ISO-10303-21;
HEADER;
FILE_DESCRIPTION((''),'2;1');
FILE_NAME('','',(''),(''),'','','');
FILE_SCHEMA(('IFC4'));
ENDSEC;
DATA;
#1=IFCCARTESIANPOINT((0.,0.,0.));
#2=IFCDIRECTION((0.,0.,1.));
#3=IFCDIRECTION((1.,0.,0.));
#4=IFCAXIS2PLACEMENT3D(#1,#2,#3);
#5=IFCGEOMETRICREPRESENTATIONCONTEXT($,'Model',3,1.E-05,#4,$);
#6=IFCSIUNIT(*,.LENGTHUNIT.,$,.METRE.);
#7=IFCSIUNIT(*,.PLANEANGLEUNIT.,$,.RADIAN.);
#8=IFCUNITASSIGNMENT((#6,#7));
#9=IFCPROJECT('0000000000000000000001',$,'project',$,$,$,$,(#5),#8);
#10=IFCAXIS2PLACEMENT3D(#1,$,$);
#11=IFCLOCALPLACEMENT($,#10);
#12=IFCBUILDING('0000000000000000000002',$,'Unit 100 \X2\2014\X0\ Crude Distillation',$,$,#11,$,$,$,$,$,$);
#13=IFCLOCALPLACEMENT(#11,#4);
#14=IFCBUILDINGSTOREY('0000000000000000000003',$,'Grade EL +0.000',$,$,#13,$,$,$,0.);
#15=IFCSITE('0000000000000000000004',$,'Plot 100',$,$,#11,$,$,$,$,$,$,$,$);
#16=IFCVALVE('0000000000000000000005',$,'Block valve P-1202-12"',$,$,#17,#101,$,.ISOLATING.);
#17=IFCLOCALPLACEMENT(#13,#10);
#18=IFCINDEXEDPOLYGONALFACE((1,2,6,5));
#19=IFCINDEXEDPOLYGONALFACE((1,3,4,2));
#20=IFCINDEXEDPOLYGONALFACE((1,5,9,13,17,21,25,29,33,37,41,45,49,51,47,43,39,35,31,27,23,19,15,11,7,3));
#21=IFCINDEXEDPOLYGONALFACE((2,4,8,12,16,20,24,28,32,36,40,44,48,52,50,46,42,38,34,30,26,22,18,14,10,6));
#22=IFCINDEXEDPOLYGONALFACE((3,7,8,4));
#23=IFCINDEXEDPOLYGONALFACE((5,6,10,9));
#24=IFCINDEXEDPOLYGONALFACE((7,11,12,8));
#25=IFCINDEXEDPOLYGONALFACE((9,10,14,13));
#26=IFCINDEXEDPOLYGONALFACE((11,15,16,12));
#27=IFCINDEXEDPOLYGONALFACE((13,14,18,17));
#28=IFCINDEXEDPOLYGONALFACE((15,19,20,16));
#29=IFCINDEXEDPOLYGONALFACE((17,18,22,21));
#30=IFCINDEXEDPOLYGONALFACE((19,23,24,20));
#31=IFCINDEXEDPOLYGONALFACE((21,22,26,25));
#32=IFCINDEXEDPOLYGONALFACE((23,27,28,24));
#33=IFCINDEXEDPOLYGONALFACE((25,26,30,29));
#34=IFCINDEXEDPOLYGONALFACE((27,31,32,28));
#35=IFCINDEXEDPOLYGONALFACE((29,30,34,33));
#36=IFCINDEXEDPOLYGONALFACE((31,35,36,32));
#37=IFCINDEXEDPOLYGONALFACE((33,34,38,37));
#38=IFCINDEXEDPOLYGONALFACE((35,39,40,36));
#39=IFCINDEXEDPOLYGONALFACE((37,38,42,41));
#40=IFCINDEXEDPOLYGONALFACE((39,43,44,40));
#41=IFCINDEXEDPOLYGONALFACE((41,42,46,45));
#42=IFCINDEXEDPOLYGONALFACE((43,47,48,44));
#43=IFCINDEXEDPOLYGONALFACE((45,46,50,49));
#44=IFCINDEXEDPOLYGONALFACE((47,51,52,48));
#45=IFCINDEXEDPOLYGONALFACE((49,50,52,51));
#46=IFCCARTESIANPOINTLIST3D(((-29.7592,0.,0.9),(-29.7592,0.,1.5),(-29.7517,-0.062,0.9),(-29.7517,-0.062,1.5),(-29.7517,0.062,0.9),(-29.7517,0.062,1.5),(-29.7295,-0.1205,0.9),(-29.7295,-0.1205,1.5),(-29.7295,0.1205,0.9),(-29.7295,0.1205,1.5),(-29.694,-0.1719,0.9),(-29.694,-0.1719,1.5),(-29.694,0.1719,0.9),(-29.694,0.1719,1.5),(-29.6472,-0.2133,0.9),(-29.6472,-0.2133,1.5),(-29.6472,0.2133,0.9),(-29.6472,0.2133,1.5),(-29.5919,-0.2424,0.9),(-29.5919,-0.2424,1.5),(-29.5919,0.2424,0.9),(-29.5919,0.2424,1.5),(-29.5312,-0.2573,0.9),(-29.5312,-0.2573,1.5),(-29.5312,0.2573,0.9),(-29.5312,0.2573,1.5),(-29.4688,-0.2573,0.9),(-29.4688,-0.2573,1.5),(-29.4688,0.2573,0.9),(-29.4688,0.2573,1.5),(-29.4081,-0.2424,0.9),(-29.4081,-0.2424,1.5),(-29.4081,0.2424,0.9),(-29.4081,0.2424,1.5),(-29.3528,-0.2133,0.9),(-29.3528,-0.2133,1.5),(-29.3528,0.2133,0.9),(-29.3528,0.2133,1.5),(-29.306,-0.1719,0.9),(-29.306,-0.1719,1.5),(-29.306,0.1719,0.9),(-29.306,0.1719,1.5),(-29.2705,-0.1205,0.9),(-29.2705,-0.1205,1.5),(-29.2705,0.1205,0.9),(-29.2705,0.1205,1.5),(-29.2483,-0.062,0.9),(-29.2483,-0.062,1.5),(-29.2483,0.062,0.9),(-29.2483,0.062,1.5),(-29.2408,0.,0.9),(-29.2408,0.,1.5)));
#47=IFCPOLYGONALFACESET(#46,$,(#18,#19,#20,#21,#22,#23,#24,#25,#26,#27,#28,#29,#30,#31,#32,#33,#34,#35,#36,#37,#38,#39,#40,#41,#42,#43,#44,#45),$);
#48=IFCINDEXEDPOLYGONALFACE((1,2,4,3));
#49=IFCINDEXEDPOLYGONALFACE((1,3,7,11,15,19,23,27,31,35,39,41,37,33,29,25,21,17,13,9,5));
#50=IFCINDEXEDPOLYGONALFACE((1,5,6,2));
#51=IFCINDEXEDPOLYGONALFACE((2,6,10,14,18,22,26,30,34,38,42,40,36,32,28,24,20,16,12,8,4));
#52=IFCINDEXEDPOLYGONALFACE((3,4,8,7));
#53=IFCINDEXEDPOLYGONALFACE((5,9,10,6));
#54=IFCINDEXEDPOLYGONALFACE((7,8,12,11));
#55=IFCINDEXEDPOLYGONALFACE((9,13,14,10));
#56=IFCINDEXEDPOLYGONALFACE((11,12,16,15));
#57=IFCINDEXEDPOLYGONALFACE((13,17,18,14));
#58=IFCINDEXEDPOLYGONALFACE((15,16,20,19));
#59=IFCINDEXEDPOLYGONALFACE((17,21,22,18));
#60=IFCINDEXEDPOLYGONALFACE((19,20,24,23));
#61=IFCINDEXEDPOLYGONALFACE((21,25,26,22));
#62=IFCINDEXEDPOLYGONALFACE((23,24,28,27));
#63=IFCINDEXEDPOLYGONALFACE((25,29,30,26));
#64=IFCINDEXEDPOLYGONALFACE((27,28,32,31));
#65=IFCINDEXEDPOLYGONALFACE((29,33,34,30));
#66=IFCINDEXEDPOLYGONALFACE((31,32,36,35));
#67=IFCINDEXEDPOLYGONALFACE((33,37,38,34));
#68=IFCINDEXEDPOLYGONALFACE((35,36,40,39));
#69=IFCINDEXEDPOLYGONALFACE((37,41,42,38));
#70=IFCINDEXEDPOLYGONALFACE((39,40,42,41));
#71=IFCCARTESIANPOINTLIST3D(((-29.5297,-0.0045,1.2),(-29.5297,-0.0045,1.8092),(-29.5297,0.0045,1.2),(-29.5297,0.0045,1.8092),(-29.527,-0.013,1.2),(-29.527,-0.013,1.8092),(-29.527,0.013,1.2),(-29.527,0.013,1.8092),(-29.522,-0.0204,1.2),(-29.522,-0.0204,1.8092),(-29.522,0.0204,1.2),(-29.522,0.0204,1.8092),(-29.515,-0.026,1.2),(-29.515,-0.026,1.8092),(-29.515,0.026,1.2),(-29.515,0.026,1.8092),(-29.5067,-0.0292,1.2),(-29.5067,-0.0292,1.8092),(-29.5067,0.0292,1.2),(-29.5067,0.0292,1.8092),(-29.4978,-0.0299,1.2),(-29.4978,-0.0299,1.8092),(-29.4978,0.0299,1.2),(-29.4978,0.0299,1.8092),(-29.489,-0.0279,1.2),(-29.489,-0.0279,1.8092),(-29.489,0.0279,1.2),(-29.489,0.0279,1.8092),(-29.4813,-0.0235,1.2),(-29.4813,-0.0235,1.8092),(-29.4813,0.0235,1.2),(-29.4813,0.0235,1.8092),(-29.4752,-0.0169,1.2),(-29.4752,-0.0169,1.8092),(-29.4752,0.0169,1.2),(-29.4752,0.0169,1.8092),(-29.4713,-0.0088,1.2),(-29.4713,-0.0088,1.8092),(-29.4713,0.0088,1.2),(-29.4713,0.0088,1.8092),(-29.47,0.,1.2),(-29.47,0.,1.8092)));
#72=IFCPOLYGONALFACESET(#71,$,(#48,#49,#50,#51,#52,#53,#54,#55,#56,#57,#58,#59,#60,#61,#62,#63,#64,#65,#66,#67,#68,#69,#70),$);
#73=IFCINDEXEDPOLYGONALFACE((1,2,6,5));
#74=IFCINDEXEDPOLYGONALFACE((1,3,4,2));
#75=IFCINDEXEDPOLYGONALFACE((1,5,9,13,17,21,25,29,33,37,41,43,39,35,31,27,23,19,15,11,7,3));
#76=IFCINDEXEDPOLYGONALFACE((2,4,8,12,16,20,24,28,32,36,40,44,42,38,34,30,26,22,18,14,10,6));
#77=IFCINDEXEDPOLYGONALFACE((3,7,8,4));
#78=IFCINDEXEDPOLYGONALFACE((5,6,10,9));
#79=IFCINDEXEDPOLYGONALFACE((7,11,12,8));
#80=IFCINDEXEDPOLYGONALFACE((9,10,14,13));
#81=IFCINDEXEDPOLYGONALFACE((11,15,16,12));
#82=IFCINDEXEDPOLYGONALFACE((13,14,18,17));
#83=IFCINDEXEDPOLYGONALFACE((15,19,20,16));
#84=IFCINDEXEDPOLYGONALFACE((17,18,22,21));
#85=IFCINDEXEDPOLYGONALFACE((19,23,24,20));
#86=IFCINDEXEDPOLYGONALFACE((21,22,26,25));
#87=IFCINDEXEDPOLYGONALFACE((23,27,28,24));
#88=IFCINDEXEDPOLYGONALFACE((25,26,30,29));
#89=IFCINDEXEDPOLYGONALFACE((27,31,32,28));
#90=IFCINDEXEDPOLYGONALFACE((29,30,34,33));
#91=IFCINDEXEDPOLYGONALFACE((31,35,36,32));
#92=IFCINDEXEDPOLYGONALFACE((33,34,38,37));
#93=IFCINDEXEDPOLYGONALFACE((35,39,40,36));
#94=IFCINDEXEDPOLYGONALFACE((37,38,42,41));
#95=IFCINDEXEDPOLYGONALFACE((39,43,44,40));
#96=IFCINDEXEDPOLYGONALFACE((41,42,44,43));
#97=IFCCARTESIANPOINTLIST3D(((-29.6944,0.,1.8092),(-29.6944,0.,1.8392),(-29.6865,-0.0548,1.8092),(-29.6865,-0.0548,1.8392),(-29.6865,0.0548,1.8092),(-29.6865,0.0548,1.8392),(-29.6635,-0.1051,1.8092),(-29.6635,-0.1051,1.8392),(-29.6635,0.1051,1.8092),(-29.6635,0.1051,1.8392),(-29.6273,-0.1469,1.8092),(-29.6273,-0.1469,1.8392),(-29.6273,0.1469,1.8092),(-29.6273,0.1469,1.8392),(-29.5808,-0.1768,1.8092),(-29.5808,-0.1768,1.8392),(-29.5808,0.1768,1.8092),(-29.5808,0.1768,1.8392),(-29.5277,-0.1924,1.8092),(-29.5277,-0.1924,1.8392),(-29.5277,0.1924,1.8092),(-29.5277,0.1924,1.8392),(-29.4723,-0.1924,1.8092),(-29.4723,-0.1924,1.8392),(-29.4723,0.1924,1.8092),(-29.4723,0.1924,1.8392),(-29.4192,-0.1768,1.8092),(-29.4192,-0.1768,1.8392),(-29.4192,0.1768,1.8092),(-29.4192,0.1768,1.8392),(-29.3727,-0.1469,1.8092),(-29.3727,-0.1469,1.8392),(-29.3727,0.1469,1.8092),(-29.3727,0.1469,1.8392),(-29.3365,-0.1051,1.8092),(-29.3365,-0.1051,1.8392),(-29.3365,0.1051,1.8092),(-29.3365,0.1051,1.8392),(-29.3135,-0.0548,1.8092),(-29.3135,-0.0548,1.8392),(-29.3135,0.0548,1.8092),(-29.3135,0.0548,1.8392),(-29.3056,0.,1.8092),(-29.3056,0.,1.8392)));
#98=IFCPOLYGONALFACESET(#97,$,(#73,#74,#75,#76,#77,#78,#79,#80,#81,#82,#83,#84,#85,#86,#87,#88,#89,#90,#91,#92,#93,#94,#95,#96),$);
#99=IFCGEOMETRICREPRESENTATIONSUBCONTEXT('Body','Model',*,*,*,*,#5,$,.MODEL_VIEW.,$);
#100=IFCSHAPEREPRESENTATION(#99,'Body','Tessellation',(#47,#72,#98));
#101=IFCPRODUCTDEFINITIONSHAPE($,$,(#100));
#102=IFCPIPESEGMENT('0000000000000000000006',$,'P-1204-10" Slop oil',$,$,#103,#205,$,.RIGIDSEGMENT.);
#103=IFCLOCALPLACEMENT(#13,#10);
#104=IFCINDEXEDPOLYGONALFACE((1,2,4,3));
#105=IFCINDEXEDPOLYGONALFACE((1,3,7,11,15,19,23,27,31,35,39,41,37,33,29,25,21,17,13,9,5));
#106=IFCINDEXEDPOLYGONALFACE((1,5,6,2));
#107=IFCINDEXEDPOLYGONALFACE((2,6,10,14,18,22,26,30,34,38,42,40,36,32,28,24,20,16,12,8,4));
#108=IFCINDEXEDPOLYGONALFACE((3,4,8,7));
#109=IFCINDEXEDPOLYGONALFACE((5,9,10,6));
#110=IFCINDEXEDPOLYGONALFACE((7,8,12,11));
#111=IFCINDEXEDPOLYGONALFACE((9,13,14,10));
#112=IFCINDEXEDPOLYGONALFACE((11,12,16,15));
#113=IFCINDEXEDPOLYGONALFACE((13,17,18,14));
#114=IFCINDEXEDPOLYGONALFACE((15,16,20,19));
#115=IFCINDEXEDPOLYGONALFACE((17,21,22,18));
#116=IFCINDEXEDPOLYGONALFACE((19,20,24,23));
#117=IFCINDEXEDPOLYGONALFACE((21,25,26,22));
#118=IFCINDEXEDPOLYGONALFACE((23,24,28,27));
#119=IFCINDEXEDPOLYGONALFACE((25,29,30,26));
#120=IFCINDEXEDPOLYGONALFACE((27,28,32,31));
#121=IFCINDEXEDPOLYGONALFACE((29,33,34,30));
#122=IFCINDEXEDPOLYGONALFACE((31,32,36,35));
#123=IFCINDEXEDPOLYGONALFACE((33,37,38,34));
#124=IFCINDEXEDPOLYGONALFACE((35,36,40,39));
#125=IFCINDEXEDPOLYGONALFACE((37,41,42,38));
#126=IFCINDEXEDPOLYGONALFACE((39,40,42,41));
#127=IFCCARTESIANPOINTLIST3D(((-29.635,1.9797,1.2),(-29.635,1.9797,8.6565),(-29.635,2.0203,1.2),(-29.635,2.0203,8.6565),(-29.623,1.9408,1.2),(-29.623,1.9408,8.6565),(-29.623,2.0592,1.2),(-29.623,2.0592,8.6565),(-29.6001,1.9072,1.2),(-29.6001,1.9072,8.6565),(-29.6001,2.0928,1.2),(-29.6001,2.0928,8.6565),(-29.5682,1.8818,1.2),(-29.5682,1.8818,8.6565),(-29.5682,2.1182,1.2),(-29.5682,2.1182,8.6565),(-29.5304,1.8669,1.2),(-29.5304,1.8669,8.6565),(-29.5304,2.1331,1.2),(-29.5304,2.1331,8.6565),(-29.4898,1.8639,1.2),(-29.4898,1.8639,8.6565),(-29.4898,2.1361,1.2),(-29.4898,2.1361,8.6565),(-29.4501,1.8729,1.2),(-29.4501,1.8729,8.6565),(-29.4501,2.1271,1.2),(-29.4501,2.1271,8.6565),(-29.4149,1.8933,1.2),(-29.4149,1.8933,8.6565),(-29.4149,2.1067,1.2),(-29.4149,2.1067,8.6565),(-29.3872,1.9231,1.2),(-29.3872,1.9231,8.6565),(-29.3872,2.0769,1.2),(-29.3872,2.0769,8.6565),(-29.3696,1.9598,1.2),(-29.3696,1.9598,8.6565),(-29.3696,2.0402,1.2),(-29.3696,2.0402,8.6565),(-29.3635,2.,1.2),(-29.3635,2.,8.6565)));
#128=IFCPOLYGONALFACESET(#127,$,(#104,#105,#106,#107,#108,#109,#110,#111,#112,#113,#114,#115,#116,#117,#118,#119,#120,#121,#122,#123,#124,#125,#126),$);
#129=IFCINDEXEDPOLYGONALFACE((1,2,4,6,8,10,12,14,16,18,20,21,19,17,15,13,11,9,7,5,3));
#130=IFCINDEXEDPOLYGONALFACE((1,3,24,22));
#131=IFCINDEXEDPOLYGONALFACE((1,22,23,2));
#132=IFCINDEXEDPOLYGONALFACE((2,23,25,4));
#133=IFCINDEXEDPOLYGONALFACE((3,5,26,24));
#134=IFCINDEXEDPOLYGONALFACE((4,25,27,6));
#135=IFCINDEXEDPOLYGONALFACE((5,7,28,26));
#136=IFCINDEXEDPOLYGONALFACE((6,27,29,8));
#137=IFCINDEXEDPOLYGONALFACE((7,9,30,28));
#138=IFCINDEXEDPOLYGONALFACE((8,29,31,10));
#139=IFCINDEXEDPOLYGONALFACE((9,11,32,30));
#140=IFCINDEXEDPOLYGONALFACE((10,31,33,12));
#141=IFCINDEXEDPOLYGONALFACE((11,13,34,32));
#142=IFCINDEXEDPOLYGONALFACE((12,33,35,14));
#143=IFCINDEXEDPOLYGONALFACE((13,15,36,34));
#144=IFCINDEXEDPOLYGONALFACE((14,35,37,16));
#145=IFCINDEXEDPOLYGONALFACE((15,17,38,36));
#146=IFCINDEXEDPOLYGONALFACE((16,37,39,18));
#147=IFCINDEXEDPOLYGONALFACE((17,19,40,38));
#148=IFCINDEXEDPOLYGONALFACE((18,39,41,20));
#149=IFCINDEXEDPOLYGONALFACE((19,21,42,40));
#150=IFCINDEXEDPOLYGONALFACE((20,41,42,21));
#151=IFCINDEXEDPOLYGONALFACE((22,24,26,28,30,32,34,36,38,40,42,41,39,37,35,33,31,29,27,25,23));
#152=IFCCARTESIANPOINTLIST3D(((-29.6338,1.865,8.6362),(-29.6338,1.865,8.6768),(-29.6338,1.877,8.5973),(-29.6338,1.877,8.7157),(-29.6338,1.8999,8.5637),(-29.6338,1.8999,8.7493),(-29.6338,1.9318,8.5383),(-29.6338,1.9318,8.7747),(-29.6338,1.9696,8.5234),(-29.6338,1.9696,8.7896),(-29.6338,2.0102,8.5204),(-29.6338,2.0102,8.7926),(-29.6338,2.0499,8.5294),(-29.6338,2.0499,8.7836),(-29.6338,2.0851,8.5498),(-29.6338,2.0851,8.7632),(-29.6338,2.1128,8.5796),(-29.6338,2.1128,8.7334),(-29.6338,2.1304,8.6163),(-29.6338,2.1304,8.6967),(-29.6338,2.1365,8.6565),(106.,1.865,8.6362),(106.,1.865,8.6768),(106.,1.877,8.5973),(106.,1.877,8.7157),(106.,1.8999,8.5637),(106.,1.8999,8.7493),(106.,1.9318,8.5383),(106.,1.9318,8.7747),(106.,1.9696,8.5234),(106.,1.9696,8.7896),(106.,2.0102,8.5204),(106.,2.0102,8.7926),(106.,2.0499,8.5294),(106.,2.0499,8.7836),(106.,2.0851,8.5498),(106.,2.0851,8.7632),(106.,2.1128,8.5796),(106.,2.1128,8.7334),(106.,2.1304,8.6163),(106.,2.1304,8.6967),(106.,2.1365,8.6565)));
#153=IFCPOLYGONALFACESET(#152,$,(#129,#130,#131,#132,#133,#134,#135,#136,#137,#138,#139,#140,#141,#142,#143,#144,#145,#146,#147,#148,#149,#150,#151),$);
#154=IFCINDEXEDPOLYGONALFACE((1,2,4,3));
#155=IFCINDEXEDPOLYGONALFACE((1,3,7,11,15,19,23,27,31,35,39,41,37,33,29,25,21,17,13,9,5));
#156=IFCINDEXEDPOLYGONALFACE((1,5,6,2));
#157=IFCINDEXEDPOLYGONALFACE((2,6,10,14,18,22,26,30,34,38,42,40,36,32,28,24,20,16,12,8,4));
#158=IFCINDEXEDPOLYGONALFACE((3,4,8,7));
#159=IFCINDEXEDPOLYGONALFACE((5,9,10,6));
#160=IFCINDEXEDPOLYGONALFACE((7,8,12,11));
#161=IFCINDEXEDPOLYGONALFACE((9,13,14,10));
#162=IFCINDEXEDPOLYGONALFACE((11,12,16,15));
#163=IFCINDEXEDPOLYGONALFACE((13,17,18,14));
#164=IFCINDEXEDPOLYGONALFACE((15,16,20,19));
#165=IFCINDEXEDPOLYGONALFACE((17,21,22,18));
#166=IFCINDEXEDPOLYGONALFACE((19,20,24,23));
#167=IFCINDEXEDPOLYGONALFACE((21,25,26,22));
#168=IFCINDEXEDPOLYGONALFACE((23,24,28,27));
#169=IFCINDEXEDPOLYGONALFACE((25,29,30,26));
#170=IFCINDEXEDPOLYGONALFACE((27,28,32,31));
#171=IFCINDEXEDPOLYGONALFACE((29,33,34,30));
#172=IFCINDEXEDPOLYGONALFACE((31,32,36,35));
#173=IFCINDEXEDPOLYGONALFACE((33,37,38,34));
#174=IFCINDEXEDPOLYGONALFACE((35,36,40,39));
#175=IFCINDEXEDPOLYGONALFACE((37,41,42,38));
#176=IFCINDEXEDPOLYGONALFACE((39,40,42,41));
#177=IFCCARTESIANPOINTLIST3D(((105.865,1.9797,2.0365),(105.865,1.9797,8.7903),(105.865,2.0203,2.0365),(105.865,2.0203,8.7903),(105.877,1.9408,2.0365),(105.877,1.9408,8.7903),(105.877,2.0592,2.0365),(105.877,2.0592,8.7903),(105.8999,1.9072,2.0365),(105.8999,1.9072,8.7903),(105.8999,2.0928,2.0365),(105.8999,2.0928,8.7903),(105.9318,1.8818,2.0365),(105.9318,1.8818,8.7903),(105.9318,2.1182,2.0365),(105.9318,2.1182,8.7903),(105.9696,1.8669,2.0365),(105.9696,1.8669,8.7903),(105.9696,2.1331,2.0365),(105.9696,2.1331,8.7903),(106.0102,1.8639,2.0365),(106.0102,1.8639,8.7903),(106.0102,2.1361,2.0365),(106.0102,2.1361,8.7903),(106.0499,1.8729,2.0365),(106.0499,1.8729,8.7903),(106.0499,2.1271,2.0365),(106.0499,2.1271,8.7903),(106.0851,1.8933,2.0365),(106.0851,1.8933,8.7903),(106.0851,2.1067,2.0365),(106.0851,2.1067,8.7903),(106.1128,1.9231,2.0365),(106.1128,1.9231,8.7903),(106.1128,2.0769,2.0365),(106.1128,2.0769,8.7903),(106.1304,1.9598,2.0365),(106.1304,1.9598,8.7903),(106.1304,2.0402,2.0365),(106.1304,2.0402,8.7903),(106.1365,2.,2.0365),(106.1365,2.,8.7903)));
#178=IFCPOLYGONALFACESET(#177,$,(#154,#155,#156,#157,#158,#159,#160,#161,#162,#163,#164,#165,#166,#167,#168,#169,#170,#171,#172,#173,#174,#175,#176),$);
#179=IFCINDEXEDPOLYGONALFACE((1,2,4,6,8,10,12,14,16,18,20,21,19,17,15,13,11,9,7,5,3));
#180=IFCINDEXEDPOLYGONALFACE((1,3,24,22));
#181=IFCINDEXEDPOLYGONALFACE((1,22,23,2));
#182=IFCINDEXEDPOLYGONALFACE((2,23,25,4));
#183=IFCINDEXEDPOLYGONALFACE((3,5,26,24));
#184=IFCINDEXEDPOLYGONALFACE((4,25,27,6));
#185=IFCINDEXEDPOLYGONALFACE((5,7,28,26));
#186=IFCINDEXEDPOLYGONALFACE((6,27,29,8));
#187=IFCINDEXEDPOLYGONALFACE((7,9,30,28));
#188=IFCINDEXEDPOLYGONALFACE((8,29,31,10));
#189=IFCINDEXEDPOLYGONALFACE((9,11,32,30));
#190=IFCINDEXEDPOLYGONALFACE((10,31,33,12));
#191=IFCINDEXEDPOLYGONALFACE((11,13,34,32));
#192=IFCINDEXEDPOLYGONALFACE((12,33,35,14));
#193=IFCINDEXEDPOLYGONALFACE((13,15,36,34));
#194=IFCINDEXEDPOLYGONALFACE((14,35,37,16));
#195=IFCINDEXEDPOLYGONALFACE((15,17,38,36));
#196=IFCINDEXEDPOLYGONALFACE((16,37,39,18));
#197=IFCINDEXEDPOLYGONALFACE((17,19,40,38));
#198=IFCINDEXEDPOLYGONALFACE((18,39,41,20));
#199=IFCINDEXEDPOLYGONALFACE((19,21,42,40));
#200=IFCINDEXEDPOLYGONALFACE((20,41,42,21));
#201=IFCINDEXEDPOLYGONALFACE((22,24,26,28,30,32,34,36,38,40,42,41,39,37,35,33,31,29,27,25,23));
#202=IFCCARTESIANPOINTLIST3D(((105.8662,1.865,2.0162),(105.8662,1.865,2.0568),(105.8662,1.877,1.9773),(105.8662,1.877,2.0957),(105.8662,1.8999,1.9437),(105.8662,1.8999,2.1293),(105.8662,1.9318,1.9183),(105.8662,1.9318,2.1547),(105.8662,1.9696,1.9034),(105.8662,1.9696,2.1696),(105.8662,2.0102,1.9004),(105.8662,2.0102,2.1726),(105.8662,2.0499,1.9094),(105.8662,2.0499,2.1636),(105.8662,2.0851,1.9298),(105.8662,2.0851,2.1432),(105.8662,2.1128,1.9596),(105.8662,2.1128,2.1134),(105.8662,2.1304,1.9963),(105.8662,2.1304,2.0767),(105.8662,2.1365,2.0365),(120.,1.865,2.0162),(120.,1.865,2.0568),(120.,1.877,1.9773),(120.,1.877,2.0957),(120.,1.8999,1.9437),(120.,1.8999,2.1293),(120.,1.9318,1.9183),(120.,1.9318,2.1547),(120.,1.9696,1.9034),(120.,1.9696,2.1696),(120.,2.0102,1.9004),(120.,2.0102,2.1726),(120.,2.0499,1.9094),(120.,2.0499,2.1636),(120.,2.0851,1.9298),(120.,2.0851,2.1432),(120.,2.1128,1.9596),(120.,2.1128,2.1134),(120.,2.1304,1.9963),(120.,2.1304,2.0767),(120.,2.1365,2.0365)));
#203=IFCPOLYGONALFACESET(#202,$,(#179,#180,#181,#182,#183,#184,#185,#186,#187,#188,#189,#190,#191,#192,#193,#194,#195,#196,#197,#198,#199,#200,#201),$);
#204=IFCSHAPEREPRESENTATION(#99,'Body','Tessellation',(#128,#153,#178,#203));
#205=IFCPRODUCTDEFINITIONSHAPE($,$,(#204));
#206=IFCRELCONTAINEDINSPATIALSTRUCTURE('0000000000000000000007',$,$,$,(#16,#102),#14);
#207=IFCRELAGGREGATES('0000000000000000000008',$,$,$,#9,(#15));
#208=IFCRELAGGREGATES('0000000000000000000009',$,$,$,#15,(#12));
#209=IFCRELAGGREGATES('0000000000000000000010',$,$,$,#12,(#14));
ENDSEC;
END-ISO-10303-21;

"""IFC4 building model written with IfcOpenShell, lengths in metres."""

from ifc_helpers import new_model, si_unit, frame, origin, origin_with_axes, origin_2d, place, context, subcontext, project, spatial, circle, extrude, element, save


model = new_model("IFC4")

# Units and contexts
model_context = context("Model", 3, precision=1e-05, world=origin_with_axes())
body_context = subcontext(model_context, "Body", "Model", "MODEL_VIEW")
ifc_project = project(units=[si_unit("LENGTHUNIT", "METRE"), si_unit("PLANEANGLEUNIT", "RADIAN")], contexts=[model_context])

# Site, building, storey
placement = place(None, origin())
site = spatial("IfcSite", under=ifc_project, at=placement, Name="Plot 100")
building = spatial("IfcBuilding", under=site, at=placement, Name="Unit 100 — Crude Distillation")
storey_placement = place(placement, origin_with_axes())
storey = spatial("IfcBuildingStorey", under=building, at=storey_placement, Name="Grade EL +0.000", Elevation=0.0)

# Valve
valve_1_placement = place(storey_placement, origin_with_axes())
element("IfcValve", 1, at=valve_1_placement, inside=storey, Name="Block valve P-1202-12\"", PredefinedType="ISOLATING", context=body_context, shape_type="SweptSolid", body=[
    extrude(circle(Radius=0.2592, at=origin_2d()), frame((-29.5, 0.0, 0.9), z_axis=(0.0, 0.0, 1.0), x_axis=(1.0, 0.0, 0.0)), (0.0, 0.0, 1.0), 0.6),
    extrude(circle(Radius=0.03, at=origin_2d()), frame((-29.5, 0.0, 1.2), z_axis=(0.0, 0.0, 1.0), x_axis=(1.0, 0.0, 0.0)), (0.0, 0.0, 1.0), 0.6092),
    extrude(circle(Radius=0.1944, at=origin_2d()), frame((-29.5, 0.0, 1.8092), z_axis=(0.0, 0.0, 1.0), x_axis=(1.0, 0.0, 0.0)), (0.0, 0.0, 1.0), 0.03),
])

# Pipe segment
pipe_segment_1_placement = place(storey_placement, origin_with_axes())
element("IfcPipeSegment", 2, at=pipe_segment_1_placement, inside=storey, Name="P-1204-10\" Slop oil", PredefinedType="RIGIDSEGMENT", context=body_context, shape_type="SweptSolid", body=[
    extrude(circle(Radius=0.1365, at=origin_2d()), frame((-29.5, 2.0, 1.2), z_axis=(0.0, 0.0, 1.0), x_axis=(1.0, 0.0, 0.0)), (0.0, 0.0, 1.0), 7.4565),
    extrude(circle(Radius=0.1365, at=origin_2d()), frame((-29.6338, 2.0, 8.6565), z_axis=(1.0, 0.0, 0.0), x_axis=(0.0, 1.0, 0.0)), (0.0, 0.0, 1.0), 135.6338),
    extrude(circle(Radius=0.1365, at=origin_2d()), frame((106.0, 2.0, 8.7903), z_axis=(0.0, 0.0, -1.0), x_axis=(1.0, 0.0, 0.0)), (0.0, 0.0, 1.0), 6.7538),
    extrude(circle(Radius=0.1365, at=origin_2d()), frame((105.8662, 2.0, 2.0365), z_axis=(1.0, 0.0, 0.0), x_axis=(0.0, 1.0, 0.0)), (0.0, 0.0, 1.0), 14.1338),
])

save(model, "model.ifc")
